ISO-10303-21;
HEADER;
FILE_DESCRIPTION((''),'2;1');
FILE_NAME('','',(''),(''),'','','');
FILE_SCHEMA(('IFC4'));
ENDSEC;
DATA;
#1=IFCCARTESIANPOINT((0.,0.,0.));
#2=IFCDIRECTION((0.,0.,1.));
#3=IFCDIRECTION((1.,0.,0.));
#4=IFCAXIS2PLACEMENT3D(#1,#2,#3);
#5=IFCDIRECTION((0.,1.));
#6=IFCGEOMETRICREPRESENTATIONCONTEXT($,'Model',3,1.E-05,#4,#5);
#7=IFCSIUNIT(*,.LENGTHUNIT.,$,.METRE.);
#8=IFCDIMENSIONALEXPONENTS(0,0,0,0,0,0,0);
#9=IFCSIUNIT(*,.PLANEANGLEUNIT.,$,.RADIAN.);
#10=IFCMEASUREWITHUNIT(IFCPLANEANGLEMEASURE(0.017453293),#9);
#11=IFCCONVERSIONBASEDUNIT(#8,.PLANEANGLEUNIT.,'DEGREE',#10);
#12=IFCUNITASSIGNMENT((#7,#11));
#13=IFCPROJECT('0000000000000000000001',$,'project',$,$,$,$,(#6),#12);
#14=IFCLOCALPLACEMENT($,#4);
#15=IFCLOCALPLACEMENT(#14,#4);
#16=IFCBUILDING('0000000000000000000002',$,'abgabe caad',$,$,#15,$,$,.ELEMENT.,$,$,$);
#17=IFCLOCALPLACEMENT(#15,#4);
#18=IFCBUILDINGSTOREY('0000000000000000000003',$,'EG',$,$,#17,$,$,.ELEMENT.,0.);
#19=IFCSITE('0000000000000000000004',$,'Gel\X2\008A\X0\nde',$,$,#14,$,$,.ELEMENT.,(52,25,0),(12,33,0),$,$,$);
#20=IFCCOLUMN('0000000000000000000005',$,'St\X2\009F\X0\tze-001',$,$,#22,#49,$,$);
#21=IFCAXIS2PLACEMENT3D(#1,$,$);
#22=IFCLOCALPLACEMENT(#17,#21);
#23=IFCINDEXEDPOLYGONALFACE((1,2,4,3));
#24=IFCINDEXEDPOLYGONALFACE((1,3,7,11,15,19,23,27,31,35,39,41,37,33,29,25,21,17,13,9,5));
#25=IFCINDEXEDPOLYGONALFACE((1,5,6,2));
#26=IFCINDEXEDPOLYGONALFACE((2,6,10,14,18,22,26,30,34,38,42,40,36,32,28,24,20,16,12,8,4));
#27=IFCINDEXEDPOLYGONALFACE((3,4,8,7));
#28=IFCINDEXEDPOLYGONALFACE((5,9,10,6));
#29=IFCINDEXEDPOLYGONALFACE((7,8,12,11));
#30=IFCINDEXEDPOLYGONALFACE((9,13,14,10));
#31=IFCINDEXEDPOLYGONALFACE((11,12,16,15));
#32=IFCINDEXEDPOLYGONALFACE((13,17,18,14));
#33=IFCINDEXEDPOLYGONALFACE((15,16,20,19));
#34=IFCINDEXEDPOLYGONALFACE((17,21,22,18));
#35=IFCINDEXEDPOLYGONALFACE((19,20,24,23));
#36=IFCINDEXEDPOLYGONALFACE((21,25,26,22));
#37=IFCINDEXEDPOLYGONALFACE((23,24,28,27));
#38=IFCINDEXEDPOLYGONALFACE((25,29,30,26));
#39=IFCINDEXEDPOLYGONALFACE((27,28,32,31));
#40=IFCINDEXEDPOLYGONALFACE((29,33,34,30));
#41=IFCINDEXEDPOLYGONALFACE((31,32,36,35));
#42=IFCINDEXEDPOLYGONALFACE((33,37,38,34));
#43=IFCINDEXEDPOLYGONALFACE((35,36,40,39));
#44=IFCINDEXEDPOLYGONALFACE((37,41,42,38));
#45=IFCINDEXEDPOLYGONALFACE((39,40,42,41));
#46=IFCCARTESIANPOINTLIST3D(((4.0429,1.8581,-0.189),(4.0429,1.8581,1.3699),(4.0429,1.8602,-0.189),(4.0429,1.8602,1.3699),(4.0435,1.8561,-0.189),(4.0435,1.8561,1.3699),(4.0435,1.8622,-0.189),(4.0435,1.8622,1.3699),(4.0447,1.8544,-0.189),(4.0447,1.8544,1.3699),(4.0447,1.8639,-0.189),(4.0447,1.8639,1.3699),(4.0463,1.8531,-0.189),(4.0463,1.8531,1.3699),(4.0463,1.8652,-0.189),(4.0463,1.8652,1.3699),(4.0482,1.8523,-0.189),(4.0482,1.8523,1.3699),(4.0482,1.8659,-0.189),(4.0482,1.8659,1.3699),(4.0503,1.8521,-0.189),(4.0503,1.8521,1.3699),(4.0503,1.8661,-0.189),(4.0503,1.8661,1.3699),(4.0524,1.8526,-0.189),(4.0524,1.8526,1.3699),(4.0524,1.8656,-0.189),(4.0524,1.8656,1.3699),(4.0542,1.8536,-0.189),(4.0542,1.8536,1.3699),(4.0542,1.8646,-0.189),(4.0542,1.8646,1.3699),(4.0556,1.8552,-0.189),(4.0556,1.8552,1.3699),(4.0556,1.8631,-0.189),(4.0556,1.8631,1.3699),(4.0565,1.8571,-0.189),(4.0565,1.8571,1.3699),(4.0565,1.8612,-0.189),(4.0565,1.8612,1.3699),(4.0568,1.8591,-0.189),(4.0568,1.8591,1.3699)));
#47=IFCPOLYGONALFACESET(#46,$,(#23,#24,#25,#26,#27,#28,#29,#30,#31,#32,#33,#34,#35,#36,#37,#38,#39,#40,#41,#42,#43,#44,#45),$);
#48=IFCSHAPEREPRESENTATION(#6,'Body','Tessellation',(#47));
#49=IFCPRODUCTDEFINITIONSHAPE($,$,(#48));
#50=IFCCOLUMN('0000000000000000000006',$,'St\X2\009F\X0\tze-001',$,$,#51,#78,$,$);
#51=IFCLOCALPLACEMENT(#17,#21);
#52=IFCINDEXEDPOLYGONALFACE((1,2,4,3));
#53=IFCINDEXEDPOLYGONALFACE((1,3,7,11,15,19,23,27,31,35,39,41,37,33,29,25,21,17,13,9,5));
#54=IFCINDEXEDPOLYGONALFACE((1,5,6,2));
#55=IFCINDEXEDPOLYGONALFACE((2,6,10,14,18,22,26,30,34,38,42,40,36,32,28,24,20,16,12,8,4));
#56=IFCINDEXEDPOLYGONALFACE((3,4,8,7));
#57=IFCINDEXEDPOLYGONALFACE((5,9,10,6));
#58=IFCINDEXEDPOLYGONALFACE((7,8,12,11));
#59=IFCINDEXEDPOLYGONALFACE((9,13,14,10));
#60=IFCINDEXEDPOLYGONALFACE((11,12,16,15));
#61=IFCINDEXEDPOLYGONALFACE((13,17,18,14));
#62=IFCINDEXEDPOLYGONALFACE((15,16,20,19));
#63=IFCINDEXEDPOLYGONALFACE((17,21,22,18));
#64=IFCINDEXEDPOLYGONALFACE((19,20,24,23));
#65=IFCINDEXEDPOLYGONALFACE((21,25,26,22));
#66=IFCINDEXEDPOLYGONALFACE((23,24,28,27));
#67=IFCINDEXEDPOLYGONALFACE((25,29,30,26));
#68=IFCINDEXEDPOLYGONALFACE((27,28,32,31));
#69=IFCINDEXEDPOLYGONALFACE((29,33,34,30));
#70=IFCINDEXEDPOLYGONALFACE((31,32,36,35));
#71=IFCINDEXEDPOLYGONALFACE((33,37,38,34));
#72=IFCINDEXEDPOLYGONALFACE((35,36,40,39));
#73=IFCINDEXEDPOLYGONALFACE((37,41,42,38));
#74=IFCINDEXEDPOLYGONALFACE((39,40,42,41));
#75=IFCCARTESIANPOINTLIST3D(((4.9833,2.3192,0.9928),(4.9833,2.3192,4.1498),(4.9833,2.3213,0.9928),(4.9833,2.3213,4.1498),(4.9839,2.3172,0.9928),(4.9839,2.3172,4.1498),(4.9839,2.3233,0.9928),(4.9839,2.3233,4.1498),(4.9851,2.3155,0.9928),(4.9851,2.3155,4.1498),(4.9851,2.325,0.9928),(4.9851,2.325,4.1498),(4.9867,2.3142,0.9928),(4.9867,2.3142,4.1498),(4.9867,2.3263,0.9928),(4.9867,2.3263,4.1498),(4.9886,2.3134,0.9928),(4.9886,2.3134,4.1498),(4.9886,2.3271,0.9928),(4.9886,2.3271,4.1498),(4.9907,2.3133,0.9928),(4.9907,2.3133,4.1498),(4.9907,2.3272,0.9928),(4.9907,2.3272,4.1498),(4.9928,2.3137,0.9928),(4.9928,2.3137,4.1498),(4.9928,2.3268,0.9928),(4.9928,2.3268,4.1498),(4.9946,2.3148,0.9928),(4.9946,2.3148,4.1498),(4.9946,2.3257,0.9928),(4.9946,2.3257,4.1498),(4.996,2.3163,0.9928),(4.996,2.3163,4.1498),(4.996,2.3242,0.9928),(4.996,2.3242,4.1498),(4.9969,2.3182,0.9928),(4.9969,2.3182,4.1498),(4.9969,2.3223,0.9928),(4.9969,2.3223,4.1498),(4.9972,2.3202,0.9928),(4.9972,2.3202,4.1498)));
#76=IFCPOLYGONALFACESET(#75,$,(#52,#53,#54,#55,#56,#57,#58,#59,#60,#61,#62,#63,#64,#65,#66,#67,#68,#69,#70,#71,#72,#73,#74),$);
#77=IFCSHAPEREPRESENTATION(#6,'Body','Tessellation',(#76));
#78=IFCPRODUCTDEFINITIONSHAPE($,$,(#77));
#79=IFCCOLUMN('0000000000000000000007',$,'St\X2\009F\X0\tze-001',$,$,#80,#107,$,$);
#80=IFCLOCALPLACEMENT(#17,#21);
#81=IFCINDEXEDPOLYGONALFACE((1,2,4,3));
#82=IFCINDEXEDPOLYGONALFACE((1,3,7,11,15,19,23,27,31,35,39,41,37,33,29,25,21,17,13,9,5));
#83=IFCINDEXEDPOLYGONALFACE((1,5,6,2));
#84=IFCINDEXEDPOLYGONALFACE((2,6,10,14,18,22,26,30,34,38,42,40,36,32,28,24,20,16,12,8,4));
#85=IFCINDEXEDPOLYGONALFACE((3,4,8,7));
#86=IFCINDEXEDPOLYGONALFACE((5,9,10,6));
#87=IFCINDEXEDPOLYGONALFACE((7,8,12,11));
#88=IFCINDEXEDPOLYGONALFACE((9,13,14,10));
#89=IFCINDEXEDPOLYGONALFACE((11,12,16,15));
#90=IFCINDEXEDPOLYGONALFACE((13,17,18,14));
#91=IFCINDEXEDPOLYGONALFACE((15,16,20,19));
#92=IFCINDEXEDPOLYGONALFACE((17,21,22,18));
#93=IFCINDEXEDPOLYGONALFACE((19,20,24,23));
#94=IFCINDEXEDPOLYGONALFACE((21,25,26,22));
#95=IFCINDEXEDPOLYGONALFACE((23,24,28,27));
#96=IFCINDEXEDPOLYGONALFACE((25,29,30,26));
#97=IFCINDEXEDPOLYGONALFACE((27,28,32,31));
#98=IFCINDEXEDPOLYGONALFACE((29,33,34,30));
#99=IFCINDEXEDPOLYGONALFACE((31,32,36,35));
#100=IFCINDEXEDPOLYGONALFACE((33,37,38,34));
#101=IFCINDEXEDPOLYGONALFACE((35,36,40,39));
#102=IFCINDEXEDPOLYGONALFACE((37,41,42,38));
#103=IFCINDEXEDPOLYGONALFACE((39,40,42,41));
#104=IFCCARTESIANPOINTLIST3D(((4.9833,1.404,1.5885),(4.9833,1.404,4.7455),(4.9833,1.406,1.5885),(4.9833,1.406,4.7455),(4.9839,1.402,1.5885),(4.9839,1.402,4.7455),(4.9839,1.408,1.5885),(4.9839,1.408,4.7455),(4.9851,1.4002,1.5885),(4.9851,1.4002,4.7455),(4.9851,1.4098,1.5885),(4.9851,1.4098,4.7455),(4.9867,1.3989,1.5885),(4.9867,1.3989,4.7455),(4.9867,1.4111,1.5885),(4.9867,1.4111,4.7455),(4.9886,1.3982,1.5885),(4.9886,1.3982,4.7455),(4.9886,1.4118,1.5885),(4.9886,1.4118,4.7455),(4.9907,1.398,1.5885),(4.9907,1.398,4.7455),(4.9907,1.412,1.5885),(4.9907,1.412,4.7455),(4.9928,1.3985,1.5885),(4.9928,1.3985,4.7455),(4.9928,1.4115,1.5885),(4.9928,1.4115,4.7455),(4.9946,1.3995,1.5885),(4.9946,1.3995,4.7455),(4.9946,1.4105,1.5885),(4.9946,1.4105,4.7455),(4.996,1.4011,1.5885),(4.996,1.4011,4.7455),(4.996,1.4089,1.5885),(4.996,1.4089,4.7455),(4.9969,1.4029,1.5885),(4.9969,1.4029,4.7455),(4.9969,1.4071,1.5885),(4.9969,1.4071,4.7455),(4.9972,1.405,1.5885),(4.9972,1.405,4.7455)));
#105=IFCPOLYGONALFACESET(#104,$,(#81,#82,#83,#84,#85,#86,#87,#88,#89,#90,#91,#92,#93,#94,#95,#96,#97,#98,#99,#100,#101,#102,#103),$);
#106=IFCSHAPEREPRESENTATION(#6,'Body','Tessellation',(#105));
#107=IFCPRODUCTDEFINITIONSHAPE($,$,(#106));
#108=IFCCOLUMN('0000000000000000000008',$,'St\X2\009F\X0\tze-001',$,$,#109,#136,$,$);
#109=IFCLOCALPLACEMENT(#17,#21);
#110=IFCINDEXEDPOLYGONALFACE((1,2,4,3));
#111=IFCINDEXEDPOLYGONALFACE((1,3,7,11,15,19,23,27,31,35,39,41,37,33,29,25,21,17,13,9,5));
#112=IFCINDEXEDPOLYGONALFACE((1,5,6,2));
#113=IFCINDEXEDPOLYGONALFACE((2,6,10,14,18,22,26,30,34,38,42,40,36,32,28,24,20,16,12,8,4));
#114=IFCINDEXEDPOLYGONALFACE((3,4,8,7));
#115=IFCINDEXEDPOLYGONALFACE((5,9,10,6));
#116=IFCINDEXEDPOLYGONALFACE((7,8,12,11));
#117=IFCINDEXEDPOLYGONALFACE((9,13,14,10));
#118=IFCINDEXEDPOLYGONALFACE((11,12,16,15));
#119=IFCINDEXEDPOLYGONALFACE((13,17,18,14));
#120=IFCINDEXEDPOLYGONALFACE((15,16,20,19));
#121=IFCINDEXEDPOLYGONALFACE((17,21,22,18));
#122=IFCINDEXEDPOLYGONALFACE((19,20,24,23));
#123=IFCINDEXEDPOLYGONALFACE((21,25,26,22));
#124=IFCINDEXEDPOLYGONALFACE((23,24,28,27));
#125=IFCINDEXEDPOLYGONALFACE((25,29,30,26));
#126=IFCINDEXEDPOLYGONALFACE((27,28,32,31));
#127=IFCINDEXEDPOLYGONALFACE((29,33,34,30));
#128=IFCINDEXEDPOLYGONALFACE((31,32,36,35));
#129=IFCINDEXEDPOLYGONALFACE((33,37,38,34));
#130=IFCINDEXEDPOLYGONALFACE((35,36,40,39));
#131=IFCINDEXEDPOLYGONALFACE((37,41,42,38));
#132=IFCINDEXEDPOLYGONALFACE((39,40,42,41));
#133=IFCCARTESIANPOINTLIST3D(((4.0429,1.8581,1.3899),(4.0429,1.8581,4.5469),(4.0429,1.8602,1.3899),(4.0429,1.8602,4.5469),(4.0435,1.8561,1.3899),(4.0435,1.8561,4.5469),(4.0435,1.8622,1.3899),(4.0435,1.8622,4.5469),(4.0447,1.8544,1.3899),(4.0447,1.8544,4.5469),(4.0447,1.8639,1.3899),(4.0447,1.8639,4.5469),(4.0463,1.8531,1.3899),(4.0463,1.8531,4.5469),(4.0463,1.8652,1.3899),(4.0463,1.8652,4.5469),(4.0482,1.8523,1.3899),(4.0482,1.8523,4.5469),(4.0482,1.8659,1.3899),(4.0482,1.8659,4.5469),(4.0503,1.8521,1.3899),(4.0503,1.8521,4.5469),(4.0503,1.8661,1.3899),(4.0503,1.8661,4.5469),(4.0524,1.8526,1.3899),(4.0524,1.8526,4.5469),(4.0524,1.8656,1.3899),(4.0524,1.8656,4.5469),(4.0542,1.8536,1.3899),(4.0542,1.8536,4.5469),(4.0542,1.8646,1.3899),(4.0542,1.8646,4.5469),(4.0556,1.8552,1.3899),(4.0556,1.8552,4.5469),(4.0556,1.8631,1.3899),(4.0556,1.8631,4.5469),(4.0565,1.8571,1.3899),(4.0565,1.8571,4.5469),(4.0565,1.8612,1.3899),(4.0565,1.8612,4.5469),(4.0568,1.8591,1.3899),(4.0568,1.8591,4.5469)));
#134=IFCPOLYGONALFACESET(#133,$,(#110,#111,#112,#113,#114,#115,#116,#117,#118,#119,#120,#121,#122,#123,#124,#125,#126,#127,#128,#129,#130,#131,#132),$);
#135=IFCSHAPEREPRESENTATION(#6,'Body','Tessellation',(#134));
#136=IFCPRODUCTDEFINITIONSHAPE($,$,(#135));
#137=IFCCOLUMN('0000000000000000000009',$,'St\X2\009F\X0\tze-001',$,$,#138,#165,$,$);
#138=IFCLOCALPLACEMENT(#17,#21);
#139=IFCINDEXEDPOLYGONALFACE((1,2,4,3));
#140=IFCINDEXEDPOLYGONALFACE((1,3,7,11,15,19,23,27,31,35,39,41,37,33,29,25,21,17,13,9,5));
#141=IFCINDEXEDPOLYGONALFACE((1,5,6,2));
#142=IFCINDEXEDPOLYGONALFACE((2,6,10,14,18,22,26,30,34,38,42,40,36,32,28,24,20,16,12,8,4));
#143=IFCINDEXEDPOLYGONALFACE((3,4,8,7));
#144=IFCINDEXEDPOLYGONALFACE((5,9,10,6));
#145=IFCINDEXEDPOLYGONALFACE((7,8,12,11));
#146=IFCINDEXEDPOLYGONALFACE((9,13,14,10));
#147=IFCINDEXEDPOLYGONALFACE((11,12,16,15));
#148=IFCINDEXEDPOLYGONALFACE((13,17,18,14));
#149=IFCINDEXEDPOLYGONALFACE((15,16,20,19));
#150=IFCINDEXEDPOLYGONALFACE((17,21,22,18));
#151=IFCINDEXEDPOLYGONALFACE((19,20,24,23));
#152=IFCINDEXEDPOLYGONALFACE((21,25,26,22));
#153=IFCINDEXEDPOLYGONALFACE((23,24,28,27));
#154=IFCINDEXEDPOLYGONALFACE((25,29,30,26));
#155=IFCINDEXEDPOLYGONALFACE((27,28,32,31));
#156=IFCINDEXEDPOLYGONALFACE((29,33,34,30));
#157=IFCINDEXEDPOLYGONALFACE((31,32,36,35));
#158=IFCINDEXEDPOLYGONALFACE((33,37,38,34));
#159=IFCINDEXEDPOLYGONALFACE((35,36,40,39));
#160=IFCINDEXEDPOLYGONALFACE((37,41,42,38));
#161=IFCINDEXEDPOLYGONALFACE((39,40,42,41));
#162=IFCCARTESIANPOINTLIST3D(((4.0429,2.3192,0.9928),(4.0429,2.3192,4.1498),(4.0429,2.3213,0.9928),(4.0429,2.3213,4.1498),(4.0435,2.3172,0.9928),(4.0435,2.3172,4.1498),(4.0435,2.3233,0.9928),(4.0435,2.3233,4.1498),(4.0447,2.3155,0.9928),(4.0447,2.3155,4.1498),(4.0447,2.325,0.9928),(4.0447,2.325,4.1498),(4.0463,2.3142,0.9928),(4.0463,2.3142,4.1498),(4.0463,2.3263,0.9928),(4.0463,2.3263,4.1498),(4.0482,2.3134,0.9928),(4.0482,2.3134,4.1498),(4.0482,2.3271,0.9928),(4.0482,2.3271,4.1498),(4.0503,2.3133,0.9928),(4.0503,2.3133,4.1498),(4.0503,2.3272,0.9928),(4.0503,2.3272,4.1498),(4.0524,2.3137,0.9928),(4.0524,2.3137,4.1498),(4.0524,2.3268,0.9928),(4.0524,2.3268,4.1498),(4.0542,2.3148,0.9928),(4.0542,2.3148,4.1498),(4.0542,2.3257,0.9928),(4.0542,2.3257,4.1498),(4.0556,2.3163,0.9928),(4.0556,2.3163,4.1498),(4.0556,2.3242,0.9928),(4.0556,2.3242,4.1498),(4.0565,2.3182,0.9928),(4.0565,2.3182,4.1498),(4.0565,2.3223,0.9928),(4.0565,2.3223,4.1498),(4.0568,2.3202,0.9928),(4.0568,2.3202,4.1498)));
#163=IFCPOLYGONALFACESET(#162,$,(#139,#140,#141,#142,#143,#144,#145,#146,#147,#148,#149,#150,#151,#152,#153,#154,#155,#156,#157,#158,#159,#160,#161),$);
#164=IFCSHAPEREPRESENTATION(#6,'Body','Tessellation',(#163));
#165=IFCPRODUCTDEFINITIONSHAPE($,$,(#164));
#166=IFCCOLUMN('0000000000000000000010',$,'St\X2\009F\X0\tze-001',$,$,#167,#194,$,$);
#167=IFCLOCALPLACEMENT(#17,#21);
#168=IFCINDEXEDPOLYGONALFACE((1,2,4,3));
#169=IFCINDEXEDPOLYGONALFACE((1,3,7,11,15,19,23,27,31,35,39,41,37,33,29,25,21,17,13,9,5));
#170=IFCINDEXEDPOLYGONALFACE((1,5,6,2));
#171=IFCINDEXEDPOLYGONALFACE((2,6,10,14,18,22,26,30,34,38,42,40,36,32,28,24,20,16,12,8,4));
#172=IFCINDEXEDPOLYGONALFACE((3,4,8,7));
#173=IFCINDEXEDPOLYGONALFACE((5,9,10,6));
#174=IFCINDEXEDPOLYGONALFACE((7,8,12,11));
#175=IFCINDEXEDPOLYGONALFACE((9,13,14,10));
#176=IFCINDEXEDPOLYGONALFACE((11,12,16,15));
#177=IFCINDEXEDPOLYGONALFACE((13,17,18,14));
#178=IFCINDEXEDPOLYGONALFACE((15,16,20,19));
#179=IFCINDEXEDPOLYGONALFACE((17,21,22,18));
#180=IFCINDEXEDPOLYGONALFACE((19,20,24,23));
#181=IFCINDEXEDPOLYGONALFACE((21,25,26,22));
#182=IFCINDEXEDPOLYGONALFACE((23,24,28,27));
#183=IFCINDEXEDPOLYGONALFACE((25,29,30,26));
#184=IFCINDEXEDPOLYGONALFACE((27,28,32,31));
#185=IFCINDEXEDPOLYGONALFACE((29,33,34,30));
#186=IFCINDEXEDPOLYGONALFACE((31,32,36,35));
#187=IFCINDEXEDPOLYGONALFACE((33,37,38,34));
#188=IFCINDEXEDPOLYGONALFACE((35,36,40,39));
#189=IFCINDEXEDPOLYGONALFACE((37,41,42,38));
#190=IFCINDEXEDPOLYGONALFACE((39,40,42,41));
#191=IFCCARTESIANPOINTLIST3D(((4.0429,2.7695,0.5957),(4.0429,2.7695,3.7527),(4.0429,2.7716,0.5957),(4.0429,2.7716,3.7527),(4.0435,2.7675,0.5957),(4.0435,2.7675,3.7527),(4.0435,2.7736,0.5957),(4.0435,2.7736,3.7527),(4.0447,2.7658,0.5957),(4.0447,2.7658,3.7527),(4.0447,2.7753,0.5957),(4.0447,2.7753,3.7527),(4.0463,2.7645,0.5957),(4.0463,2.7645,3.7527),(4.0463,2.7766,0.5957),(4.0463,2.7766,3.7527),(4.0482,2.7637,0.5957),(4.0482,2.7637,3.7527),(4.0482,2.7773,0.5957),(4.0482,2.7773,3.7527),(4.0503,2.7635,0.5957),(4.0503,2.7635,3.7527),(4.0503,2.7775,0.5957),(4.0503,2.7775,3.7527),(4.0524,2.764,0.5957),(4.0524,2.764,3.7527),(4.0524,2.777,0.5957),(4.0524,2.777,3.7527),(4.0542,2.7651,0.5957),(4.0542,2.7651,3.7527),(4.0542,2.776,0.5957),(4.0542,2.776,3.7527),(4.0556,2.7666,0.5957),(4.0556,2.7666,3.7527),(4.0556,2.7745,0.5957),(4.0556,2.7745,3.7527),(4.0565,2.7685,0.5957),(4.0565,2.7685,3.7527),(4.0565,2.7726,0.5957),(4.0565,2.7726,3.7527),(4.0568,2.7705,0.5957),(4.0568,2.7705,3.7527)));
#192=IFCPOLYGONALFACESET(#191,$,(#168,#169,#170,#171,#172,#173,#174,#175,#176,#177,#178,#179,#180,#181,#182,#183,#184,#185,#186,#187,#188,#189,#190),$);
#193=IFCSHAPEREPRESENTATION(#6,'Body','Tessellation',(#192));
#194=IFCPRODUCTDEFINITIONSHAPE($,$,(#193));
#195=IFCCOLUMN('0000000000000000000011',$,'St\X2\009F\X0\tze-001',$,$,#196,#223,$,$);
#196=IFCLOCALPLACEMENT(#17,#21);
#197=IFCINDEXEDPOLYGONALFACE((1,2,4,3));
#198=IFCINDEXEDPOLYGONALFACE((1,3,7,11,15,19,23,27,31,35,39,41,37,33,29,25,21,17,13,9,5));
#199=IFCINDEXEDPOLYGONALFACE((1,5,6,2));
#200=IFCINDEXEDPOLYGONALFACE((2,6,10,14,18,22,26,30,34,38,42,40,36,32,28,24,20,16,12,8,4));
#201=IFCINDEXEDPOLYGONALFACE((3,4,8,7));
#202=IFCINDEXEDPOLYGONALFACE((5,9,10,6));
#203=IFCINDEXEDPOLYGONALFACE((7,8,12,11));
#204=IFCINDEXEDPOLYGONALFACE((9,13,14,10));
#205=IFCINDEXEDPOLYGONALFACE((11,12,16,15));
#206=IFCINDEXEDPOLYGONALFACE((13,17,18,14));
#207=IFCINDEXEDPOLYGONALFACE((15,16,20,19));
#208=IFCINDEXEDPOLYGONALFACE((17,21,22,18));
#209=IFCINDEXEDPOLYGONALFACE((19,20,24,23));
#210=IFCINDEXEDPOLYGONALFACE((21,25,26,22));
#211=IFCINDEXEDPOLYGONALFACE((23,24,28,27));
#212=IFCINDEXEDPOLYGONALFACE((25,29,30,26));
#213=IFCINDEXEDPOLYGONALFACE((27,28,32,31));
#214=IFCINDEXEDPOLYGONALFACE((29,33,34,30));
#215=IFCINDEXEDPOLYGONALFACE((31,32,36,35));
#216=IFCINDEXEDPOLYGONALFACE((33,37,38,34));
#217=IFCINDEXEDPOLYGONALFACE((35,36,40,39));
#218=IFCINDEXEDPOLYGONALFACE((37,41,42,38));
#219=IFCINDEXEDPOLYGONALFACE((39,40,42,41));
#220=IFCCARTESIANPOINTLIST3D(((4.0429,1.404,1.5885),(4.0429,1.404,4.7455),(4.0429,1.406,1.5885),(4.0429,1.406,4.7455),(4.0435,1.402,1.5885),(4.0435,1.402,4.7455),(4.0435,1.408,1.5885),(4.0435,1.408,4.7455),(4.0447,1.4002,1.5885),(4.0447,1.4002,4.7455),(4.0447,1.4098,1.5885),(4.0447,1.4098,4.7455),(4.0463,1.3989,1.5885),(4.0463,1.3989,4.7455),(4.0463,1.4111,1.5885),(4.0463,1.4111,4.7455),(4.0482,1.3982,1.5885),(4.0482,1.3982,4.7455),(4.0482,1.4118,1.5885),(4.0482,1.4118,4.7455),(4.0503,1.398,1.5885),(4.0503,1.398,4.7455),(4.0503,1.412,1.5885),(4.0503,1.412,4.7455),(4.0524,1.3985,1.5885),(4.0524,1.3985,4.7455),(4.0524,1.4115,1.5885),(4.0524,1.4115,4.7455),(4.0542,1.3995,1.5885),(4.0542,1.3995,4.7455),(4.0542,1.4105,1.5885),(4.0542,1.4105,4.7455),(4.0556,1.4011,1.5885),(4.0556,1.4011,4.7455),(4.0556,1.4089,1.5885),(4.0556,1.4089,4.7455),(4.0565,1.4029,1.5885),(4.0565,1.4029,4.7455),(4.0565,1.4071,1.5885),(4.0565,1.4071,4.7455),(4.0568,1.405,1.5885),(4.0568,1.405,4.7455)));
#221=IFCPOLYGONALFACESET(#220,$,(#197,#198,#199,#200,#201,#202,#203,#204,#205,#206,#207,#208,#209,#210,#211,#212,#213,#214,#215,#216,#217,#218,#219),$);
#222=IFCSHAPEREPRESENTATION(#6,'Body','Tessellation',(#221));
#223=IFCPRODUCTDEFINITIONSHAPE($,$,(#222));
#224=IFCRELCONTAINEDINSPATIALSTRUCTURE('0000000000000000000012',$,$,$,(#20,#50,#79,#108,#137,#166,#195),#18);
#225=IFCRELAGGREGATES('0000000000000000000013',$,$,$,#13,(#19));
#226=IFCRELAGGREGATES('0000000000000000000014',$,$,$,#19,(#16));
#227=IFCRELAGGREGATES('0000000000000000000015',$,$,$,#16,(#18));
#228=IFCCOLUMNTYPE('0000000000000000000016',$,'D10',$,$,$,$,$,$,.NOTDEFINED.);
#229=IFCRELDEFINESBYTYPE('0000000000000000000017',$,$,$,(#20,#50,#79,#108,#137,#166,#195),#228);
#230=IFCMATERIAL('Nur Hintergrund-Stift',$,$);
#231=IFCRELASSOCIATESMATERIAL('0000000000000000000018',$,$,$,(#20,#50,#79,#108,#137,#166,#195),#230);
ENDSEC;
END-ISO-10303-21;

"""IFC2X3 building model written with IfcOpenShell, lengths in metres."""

from ifc_helpers import new_model, entity, si_unit, converted_unit, direction, frame, origin_with_axes, origin_2d_with_axis, place, context, project, spatial, circle, extrude, material, type_object, element, save


model = new_model("IFC2X3")

# Units and contexts
model_context = context("Model", 3, precision=1e-05, world=origin_with_axes(), true_north=direction((0.0, 1.0)))
ifc_project = project(units=[si_unit("LENGTHUNIT", "METRE"), converted_unit("PLANEANGLEUNIT", "DEGREE", entity("IfcPlaneAngleMeasure", 0.017453293), si_unit("PLANEANGLEUNIT", "RADIAN"), dimensions=[0, 0, 0, 0, 0, 0, 0])], contexts=[model_context])

# Site, building, storey
site_placement = place(None, origin_with_axes())
site = spatial("IfcSite", under=ifc_project, at=site_placement, Name="Gel\u008ande", CompositionType="ELEMENT", RefLatitude=(52, 25, 0), RefLongitude=(12, 33, 0))
building_placement = place(site_placement, origin_with_axes())
building = spatial("IfcBuilding", under=site, at=building_placement, Name="abgabe caad", CompositionType="ELEMENT")
storey_placement = place(building_placement, origin_with_axes())
storey = spatial("IfcBuildingStorey", under=building, at=storey_placement, Name="EG", CompositionType="ELEMENT", Elevation=0.0)

# Columns
ifc_material_1 = material(Name="Nur Hintergrund-Stift")
column_type = type_object("IfcColumnType", Name="D10", PredefinedType="NOTDEFINED")
column_1_placement = place(storey_placement, frame((4.0498, 1.8591, -0.189), z_axis=(0.0, 0.0, 1.0), x_axis=(1.0, 0.0, 0.0)))
element("IfcColumn", 1, at=column_1_placement, inside=storey, type_object=column_type, material=ifc_material_1, Name="St\u009ftze-001", context=model_context, shape_type="SweptSolid", body=[
    extrude(circle(Radius=0.007, at=origin_2d_with_axis()), origin_with_axes(), (0.0, 0.0, 1.0), 1.5589),
])
for number, where, z_axis, x_axis, name in (
    (2, (4.9902, 2.3202, 0.9928), (0.0, 0.0, 1.0), (1.0, 0.0, 0.0), "St\u009ftze-001"),
    (3, (4.9902, 1.405, 1.5885), (0.0, 0.0, 1.0), (1.0, 0.0, 0.0), "St\u009ftze-001"),
    (4, (4.0498, 1.8591, 1.3899), (0.0, 0.0, 1.0), (1.0, 0.0, 0.0), "St\u009ftze-001"),
    (5, (4.0498, 2.3202, 0.9928), (0.0, 0.0, 1.0), (1.0, 0.0, 0.0), "St\u009ftze-001"),
    (6, (4.0498, 2.7705, 0.5957), (0.0, 0.0, 1.0), (1.0, 0.0, 0.0), "St\u009ftze-001"),
    (7, (4.0498, 1.405, 1.5885), (0.0, 0.0, 1.0), (1.0, 0.0, 0.0), "St\u009ftze-001"),
):
    element("IfcColumn", number, at=place(storey_placement, frame(where, z_axis=z_axis, x_axis=x_axis)), inside=storey, type_object=column_type, material=ifc_material_1, Name=name, context=model_context, shape_type="SweptSolid", body=[
        extrude(circle(Radius=0.007, at=origin_2d_with_axis()), origin_with_axes(), (0.0, 0.0, 1.0), 3.157),
    ])

save(model, "model.ifc")
